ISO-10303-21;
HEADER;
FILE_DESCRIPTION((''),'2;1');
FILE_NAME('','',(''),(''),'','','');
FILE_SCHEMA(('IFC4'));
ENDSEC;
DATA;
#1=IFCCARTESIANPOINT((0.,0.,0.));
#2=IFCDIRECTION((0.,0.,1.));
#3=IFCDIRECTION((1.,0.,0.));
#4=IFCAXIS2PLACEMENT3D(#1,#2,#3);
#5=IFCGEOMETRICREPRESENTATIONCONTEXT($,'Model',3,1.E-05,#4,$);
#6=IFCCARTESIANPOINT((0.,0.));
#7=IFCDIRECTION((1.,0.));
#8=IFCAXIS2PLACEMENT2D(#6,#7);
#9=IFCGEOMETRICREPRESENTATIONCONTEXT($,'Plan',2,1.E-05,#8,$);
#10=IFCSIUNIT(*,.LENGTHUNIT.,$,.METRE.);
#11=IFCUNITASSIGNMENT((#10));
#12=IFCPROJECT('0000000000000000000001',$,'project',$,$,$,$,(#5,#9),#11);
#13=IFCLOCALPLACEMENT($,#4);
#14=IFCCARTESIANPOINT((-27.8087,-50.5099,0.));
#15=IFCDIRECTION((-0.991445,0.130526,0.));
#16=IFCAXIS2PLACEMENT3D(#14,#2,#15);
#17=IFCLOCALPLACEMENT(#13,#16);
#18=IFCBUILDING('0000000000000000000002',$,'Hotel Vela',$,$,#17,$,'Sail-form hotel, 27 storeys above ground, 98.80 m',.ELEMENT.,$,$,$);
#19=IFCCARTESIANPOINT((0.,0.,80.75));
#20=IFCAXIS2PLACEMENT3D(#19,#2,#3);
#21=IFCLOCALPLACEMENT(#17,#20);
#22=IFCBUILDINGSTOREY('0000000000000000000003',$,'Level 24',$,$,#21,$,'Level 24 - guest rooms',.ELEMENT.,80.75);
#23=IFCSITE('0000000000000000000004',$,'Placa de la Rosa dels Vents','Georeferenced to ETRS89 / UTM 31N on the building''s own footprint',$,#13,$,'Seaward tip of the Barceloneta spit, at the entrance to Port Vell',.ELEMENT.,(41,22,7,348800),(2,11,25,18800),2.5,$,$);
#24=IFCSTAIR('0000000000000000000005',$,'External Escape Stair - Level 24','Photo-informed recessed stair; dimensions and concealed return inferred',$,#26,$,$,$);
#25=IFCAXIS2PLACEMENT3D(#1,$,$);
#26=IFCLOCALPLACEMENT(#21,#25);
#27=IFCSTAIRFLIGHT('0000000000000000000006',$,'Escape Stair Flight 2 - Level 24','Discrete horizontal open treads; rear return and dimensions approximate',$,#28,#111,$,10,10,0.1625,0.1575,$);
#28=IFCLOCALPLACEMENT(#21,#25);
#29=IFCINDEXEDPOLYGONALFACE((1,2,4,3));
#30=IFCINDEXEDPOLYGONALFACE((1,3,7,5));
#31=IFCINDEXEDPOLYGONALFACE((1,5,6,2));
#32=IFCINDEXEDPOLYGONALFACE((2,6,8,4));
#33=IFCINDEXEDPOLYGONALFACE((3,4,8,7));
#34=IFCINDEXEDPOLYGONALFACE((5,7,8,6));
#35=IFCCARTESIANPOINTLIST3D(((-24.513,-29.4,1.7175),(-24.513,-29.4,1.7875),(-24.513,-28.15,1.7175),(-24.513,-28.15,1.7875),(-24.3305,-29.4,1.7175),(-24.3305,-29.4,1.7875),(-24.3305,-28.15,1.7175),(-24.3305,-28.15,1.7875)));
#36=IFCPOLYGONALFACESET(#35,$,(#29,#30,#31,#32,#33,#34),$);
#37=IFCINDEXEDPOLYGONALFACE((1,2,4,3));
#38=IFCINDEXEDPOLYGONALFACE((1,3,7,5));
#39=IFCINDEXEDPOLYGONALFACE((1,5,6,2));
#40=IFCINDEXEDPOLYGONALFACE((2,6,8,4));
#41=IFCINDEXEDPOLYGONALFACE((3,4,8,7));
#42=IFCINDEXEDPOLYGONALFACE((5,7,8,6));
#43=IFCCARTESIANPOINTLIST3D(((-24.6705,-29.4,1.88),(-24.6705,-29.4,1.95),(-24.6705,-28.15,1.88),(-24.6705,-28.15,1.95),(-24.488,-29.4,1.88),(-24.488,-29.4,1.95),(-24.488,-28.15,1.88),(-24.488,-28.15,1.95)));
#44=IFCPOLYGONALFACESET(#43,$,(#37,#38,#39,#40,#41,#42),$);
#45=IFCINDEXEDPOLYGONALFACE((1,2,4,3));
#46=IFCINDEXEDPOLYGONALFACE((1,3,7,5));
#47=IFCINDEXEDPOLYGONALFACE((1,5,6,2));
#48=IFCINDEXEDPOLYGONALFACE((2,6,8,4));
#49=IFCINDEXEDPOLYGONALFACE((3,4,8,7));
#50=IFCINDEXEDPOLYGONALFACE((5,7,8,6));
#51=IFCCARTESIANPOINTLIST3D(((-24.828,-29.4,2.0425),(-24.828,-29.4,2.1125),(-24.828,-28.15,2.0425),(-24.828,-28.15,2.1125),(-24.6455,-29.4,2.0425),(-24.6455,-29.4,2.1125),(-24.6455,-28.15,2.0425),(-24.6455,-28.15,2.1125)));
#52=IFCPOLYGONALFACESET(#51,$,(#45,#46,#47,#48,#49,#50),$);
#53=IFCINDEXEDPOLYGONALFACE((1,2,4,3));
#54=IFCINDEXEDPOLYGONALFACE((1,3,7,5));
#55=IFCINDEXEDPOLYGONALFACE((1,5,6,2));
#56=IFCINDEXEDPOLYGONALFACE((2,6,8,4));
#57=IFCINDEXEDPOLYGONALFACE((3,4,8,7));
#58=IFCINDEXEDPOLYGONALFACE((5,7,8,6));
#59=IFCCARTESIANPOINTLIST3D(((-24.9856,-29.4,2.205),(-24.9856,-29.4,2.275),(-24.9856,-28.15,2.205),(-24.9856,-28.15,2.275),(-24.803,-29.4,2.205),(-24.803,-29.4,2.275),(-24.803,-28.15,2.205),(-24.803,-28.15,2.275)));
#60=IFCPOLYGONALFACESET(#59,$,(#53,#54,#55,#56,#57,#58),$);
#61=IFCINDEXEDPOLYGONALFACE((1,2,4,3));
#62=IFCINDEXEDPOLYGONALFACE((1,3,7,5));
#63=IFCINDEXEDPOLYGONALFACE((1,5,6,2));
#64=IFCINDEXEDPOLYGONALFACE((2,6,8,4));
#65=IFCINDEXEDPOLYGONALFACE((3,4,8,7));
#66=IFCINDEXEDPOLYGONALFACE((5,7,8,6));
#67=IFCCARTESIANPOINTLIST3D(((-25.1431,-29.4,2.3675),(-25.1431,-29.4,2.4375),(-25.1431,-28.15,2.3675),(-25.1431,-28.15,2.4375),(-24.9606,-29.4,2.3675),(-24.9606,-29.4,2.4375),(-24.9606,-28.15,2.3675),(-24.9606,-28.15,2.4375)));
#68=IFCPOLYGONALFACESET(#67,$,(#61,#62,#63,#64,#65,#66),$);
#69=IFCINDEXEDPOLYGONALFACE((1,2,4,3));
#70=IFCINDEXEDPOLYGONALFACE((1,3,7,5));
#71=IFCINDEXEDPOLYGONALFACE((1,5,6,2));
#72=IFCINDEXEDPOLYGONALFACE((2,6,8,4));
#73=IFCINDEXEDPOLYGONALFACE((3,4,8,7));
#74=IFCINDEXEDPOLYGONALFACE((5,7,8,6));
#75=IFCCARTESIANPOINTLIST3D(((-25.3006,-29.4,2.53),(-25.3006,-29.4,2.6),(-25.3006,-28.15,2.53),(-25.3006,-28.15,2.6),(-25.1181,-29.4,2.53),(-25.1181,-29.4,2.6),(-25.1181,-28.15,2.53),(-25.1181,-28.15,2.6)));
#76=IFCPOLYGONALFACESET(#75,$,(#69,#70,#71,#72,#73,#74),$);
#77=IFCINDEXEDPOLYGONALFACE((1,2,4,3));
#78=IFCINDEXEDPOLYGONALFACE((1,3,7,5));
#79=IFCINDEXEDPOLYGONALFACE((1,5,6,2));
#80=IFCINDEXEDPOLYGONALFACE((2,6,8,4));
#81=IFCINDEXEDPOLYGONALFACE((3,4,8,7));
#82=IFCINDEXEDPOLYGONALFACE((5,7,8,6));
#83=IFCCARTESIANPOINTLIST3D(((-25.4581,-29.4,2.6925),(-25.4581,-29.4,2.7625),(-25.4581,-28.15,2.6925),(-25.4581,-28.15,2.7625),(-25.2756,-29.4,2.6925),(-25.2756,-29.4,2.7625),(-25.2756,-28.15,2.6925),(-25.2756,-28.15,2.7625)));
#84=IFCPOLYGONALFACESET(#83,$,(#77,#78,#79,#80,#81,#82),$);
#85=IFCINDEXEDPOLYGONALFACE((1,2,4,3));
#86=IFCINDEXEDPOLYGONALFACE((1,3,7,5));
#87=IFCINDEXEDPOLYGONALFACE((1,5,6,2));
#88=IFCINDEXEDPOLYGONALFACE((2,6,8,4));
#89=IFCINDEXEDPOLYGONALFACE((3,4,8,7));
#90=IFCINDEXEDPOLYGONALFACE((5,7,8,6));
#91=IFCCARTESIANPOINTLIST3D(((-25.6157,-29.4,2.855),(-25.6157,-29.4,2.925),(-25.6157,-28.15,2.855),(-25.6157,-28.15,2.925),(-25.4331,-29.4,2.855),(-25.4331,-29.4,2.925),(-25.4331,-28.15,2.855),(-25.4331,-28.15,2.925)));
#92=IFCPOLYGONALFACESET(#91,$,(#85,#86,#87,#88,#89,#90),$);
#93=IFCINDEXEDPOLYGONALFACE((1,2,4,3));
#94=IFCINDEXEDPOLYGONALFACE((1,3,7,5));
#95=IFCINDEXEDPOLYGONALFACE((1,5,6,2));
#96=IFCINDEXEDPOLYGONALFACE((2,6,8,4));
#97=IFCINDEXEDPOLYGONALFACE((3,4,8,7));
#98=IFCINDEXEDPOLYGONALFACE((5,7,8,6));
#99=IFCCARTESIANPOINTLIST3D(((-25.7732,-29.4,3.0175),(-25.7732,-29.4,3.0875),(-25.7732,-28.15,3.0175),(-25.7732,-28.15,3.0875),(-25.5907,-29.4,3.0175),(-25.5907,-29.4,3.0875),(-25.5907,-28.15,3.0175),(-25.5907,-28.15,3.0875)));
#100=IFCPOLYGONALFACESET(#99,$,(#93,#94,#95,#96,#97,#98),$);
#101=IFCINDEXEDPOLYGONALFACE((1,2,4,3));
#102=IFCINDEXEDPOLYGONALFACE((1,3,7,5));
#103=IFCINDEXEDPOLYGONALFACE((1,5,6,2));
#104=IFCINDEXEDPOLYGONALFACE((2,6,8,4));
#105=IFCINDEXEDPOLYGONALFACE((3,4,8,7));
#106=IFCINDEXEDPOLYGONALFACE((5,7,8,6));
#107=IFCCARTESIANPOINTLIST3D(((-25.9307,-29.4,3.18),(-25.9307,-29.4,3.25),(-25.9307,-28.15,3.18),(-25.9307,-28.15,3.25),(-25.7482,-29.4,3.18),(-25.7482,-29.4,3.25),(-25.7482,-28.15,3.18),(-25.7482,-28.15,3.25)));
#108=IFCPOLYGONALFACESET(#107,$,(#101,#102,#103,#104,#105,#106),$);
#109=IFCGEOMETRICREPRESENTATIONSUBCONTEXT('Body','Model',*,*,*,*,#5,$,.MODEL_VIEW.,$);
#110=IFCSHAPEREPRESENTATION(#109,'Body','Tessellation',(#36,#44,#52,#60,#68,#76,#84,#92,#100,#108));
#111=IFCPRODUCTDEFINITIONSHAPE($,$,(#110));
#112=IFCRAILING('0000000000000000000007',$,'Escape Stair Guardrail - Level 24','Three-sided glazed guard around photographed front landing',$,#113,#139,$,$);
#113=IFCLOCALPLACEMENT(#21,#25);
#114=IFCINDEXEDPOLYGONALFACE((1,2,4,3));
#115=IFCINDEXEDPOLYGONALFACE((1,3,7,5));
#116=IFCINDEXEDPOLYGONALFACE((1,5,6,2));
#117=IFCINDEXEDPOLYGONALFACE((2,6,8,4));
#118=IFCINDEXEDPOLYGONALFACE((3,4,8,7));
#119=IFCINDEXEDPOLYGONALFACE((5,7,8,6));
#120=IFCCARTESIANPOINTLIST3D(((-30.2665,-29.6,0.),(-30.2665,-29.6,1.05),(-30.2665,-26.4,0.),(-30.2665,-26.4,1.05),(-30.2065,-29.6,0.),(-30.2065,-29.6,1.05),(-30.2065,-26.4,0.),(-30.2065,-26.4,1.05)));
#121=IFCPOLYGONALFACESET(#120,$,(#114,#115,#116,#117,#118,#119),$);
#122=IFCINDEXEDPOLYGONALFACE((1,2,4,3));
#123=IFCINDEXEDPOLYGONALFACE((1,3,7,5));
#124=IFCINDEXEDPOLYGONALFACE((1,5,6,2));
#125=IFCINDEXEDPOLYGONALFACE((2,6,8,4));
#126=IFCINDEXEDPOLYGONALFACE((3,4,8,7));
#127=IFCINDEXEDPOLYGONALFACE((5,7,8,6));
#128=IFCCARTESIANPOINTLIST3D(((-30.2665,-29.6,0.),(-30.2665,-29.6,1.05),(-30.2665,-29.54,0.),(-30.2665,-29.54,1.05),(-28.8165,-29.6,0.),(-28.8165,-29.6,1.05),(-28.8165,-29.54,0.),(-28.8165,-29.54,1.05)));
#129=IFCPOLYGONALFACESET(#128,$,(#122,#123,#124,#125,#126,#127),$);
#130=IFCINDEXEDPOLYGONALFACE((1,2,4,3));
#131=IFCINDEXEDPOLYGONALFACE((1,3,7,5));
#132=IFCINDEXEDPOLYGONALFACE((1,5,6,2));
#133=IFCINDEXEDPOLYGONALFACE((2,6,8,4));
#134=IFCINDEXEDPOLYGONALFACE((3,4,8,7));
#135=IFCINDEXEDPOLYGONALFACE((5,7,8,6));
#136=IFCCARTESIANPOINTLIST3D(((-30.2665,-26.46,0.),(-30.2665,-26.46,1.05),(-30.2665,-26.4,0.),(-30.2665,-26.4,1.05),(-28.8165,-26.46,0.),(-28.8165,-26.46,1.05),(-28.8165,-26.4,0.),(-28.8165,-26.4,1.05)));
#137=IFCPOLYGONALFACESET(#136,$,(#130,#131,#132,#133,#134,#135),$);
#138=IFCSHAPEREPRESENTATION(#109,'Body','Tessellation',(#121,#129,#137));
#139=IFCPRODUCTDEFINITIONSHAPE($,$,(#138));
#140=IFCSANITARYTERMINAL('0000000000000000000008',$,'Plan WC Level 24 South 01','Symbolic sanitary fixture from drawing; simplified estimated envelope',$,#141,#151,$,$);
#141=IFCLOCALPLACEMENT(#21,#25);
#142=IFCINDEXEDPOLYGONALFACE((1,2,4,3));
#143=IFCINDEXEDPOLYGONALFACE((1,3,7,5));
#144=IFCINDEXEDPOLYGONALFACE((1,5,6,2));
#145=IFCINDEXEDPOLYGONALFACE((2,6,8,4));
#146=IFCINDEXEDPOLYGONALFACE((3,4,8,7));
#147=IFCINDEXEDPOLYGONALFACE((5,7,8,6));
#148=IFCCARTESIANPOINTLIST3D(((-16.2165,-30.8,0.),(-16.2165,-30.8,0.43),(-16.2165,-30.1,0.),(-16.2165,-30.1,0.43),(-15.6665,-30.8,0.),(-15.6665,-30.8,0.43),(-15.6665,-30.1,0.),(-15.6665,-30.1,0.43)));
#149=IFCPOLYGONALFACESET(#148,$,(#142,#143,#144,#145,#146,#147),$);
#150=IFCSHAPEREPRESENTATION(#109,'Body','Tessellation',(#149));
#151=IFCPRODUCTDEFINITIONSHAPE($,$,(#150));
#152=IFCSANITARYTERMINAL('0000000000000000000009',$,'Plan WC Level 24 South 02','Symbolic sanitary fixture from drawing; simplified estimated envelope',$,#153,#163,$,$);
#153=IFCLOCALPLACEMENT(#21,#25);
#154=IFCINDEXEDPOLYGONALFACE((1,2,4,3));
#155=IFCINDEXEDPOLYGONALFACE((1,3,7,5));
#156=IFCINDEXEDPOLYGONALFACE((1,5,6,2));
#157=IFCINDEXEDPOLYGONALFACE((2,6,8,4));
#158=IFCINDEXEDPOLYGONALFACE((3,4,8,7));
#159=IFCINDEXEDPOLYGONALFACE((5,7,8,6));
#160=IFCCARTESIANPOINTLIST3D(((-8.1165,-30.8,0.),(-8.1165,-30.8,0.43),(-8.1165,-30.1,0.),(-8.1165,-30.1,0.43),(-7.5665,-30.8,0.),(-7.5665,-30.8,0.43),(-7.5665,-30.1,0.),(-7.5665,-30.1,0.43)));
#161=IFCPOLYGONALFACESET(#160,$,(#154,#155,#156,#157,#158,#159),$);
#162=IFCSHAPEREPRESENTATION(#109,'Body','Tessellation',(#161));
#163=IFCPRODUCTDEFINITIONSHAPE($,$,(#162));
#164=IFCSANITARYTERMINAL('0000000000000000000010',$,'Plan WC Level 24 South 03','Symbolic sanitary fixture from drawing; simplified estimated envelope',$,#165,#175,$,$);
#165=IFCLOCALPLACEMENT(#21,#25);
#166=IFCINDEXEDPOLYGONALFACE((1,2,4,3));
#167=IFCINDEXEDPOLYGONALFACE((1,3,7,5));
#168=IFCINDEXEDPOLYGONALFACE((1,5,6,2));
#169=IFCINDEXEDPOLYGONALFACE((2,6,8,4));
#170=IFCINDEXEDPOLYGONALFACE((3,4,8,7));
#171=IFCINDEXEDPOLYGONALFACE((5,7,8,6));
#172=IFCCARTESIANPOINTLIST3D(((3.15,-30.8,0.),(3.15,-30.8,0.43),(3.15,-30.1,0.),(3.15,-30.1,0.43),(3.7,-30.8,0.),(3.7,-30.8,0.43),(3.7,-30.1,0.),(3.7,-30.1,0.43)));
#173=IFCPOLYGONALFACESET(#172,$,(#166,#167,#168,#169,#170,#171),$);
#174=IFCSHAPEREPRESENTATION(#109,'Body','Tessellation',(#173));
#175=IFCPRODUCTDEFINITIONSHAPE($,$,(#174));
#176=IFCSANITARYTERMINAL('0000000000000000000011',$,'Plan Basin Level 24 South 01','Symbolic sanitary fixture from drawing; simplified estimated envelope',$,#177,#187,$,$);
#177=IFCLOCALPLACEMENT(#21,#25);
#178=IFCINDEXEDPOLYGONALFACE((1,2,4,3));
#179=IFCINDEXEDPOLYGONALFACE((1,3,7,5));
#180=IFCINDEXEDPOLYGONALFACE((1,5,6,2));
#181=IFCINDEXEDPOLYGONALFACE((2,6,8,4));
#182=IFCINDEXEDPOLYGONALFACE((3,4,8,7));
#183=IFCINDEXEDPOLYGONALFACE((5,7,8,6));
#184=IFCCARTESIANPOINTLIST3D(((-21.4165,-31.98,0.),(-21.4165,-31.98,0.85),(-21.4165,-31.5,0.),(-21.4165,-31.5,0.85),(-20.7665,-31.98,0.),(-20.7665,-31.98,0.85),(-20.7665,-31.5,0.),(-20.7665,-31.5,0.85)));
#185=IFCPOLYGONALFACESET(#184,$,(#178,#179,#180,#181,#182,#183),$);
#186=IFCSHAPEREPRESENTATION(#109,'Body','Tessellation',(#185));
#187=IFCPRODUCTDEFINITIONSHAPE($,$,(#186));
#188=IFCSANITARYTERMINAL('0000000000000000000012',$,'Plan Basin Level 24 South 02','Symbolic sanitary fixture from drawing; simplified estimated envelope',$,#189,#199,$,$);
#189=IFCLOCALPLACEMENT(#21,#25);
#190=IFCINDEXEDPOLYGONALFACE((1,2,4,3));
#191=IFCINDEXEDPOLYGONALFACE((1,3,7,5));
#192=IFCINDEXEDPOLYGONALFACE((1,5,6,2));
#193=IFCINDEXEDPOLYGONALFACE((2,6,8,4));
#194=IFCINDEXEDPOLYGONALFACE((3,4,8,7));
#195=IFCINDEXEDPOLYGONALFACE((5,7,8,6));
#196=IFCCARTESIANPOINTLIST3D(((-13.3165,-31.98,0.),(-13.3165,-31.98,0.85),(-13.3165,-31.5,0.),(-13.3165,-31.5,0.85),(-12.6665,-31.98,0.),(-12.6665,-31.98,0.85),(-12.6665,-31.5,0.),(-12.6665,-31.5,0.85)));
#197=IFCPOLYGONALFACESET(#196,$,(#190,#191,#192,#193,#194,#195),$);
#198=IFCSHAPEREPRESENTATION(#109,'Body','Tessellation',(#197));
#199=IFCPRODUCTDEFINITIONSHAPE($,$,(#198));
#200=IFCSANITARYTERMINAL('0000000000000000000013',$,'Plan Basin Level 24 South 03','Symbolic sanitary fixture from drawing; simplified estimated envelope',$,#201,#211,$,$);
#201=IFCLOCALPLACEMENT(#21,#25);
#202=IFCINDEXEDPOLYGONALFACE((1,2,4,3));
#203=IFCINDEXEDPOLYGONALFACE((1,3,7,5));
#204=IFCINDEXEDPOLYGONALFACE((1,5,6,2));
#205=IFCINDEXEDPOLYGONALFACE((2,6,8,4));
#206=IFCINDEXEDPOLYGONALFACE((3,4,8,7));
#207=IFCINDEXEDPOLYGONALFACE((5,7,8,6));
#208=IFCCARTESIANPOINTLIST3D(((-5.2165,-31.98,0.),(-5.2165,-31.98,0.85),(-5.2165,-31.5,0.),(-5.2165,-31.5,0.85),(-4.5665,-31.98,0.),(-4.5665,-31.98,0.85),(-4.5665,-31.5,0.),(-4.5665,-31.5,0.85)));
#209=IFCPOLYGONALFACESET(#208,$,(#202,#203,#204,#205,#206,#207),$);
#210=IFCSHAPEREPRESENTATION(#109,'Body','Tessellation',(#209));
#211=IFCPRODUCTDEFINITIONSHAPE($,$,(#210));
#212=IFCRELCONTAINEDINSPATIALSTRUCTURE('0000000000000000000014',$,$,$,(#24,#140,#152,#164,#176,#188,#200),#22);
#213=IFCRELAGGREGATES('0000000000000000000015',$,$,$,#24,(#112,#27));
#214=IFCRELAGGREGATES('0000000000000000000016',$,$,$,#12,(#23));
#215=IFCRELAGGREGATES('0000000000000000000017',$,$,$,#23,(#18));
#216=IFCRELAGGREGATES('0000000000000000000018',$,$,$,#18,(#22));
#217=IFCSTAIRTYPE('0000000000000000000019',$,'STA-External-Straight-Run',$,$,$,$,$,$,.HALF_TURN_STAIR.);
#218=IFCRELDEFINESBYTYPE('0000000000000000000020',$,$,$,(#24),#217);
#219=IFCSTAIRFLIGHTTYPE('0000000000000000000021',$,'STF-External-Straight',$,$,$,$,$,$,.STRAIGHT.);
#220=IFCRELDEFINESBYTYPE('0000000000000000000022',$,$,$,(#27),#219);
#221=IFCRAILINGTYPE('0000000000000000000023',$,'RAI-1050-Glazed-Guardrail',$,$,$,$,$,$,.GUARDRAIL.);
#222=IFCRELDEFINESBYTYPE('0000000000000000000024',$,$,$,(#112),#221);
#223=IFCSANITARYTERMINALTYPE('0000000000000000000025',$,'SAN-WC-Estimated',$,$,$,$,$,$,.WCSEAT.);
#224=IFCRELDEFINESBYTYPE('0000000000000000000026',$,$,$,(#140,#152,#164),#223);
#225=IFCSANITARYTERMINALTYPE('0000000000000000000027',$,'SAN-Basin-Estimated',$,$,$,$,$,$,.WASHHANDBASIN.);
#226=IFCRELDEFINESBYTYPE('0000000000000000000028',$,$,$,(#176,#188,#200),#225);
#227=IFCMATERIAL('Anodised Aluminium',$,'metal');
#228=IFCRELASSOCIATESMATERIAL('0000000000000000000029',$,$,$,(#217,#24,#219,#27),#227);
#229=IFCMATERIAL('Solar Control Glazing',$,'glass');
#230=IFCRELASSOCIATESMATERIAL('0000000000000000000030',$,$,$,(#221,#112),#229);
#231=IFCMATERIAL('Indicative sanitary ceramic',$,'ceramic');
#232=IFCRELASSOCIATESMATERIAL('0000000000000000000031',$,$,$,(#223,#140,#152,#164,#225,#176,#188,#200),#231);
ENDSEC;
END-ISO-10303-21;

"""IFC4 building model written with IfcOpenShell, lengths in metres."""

from ifc_helpers import new_model, si_unit, frame, origin_with_axes, origin_2d_with_axis, place, context, subcontext, project, spatial, line, indexed_curve, outline, extrude, material, type_object, element, aggregate, save


model = new_model("IFC4")

# Units and contexts
model_context = context("Model", 3, precision=1e-05, world=origin_with_axes())
plan_context = context("Plan", 2, precision=1e-05, world=origin_2d_with_axis())
body_context = subcontext(model_context, "Body", "Model", "MODEL_VIEW")
ifc_project = project(units=[si_unit("LENGTHUNIT", "METRE")], contexts=[model_context, plan_context])

# Site, building, storey
site_placement = place(None, origin_with_axes())
site = spatial("IfcSite", under=ifc_project, at=site_placement, Name="Placa de la Rosa dels Vents", Description="Georeferenced to ETRS89 / UTM 31N on the building's own footprint", LongName="Seaward tip of the Barceloneta spit, at the entrance to Port Vell", CompositionType="ELEMENT", RefLatitude=(41, 22, 7, 348800), RefLongitude=(2, 11, 25, 18800), RefElevation=2.5)
building_placement = place(site_placement, frame((-27.8087, -50.5099, 0.0), z_axis=(0.0, 0.0, 1.0), x_axis=(-0.991445, 0.130526, 0.0)))
building = spatial("IfcBuilding", under=site, at=building_placement, Name="Hotel Vela", LongName="Sail-form hotel, 27 storeys above ground, 98.80 m", CompositionType="ELEMENT")
storey_placement = place(building_placement, frame((0.0, 0.0, 80.75), z_axis=(0.0, 0.0, 1.0), x_axis=(1.0, 0.0, 0.0)))
storey = spatial("IfcBuildingStorey", under=building, at=storey_placement, Name="Level 24", LongName="Level 24 - guest rooms", CompositionType="ELEMENT", Elevation=80.75)

# Stair
ifc_material_1 = material(Name="Anodised Aluminium", Category="metal")
stair_type = type_object("IfcStairType", Name="STA-External-Straight-Run", PredefinedType="HALF_TURN_STAIR", material=ifc_material_1)
stair_placement = place(storey_placement, frame((0.0, 0.0, -80.75), z_axis=(0.0, 0.0, 1.0), x_axis=(1.0, 0.0, 0.0)))
stair = element("IfcStair", 1, at=stair_placement, inside=storey, type_object=stair_type, material=ifc_material_1, Name="External Escape Stair - Level 24", Description="Photo-informed recessed stair; dimensions and concealed return inferred")

# Stair flight
stair_flight_type = type_object("IfcStairFlightType", Name="STF-External-Straight", PredefinedType="STRAIGHT", material=ifc_material_1)
stair_flight_1_placement = place(stair_placement, origin_with_axes())
stair_flight_1 = element("IfcStairFlight", 2, at=stair_flight_1_placement, type_object=stair_flight_type, material=ifc_material_1, Name="Escape Stair Flight 2 - Level 24", Description="Discrete horizontal open treads; rear return and dimensions approximate", NumberOfRisers=10, NumberOfTreads=10, RiserHeight=0.1625, TreadLength=0.1575, context=body_context, shape_type="SweptSolid", body=[
    extrude(outline(indexed_curve([(0.0, 0.0), (0.1825, 0.0), (0.1825, 1.25), (0.0, 1.25)], segments=[line(1, 2, 3, 4, 1)])), frame((-24.513, -29.4, 82.4675), z_axis=(0.0, 0.0, 1.0), x_axis=(1.0, 0.0, 0.0)), (0.0, 0.0, 1.0), 0.07),
    extrude(outline(indexed_curve([(0.0, 0.0), (0.1825, 0.0), (0.1825, 1.25), (0.0, 1.25)], segments=[line(1, 2, 3, 4, 1)])), frame((-24.6705, -29.4, 82.63), z_axis=(0.0, 0.0, 1.0), x_axis=(1.0, 0.0, 0.0)), (0.0, 0.0, 1.0), 0.07),
    extrude(outline(indexed_curve([(0.0, 0.0), (0.1825, 0.0), (0.1825, 1.25), (0.0, 1.25)], segments=[line(1, 2, 3, 4, 1)])), frame((-24.828, -29.4, 82.7925), z_axis=(0.0, 0.0, 1.0), x_axis=(1.0, 0.0, 0.0)), (0.0, 0.0, 1.0), 0.07),
    extrude(outline(indexed_curve([(0.0, 0.0), (0.1825, 0.0), (0.1825, 1.25), (0.0, 1.25)], segments=[line(1, 2, 3, 4, 1)])), frame((-24.9856, -29.4, 82.955), z_axis=(0.0, 0.0, 1.0), x_axis=(1.0, 0.0, 0.0)), (0.0, 0.0, 1.0), 0.07),
    extrude(outline(indexed_curve([(0.0, 0.0), (0.1825, 0.0), (0.1825, 1.25), (0.0, 1.25)], segments=[line(1, 2, 3, 4, 1)])), frame((-25.1431, -29.4, 83.1175), z_axis=(0.0, 0.0, 1.0), x_axis=(1.0, 0.0, 0.0)), (0.0, 0.0, 1.0), 0.07),
    extrude(outline(indexed_curve([(0.0, 0.0), (0.1825, 0.0), (0.1825, 1.25), (0.0, 1.25)], segments=[line(1, 2, 3, 4, 1)])), frame((-25.3006, -29.4, 83.28), z_axis=(0.0, 0.0, 1.0), x_axis=(1.0, 0.0, 0.0)), (0.0, 0.0, 1.0), 0.07),
    extrude(outline(indexed_curve([(0.0, 0.0), (0.1825, 0.0), (0.1825, 1.25), (0.0, 1.25)], segments=[line(1, 2, 3, 4, 1)])), frame((-25.4581, -29.4, 83.4425), z_axis=(0.0, 0.0, 1.0), x_axis=(1.0, 0.0, 0.0)), (0.0, 0.0, 1.0), 0.07),
    extrude(outline(indexed_curve([(0.0, 0.0), (0.1825, 0.0), (0.1825, 1.25), (0.0, 1.25)], segments=[line(1, 2, 3, 4, 1)])), frame((-25.6157, -29.4, 83.605), z_axis=(0.0, 0.0, 1.0), x_axis=(1.0, 0.0, 0.0)), (0.0, 0.0, 1.0), 0.07),
    extrude(outline(indexed_curve([(0.0, 0.0), (0.1825, 0.0), (0.1825, 1.25), (0.0, 1.25)], segments=[line(1, 2, 3, 4, 1)])), frame((-25.7732, -29.4, 83.7675), z_axis=(0.0, 0.0, 1.0), x_axis=(1.0, 0.0, 0.0)), (0.0, 0.0, 1.0), 0.07),
    extrude(outline(indexed_curve([(0.0, 0.0), (0.1825, 0.0), (0.1825, 1.25), (0.0, 1.25)], segments=[line(1, 2, 3, 4, 1)])), frame((-25.9307, -29.4, 83.93), z_axis=(0.0, 0.0, 1.0), x_axis=(1.0, 0.0, 0.0)), (0.0, 0.0, 1.0), 0.07),
])

# Railing
ifc_material_2 = material(Name="Solar Control Glazing", Category="glass")
railing_type = type_object("IfcRailingType", Name="RAI-1050-Glazed-Guardrail", PredefinedType="GUARDRAIL", material=ifc_material_2)
railing_placement = place(stair_placement, origin_with_axes())
railing = element("IfcRailing", 3, at=railing_placement, type_object=railing_type, material=ifc_material_2, Name="Escape Stair Guardrail - Level 24", Description="Three-sided glazed guard around photographed front landing", context=body_context, shape_type="SweptSolid", body=[
    extrude(outline(indexed_curve([(0.0, 0.0), (0.06, 0.0), (0.06, 3.2), (0.0, 3.2)], segments=[line(1, 2, 3, 4, 1)])), frame((-30.2665, -29.6, 80.75), z_axis=(0.0, 0.0, 1.0), x_axis=(1.0, 0.0, 0.0)), (0.0, 0.0, 1.0), 1.05),
    extrude(outline(indexed_curve([(0.0, 0.0), (1.45, 0.0), (1.45, 0.06), (0.0, 0.06)], segments=[line(1, 2, 3, 4, 1)])), frame((-30.2665, -29.6, 80.75), z_axis=(0.0, 0.0, 1.0), x_axis=(1.0, 0.0, 0.0)), (0.0, 0.0, 1.0), 1.05),
    extrude(outline(indexed_curve([(0.0, 0.0), (1.45, 0.0), (1.45, 0.06), (0.0, 0.06)], segments=[line(1, 2, 3, 4, 1)])), frame((-30.2665, -26.46, 80.75), z_axis=(0.0, 0.0, 1.0), x_axis=(1.0, 0.0, 0.0)), (0.0, 0.0, 1.0), 1.05),
])
aggregate(stair, [railing, stair_flight_1])

# Sanitary terminals
ifc_material_3 = material(Name="Indicative sanitary ceramic", Category="ceramic")
sanitary_terminal_type_1 = type_object("IfcSanitaryTerminalType", Name="SAN-WC-Estimated", PredefinedType="WCSEAT", material=ifc_material_3)
for number, where, z_axis, x_axis, name in (
    (4, (-16.2165, -30.8, 0.0), (0.0, 0.0, 1.0), (1.0, 0.0, 0.0), "Plan WC Level 24 South 01"),
    (5, (-8.1165, -30.8, 0.0), (0.0, 0.0, 1.0), (1.0, 0.0, 0.0), "Plan WC Level 24 South 02"),
    (6, (3.15, -30.8, 0.0), (0.0, 0.0, 1.0), (1.0, 0.0, 0.0), "Plan WC Level 24 South 03"),
):
    element("IfcSanitaryTerminal", number, at=place(storey_placement, frame(where, z_axis=z_axis, x_axis=x_axis)), inside=storey, type_object=sanitary_terminal_type_1, material=ifc_material_3, Name=name, Description="Symbolic sanitary fixture from drawing; simplified estimated envelope", context=body_context, shape_type="SweptSolid", body=[
        extrude(outline(indexed_curve([(0.0, 0.0), (0.55, 0.0), (0.55, 0.7), (0.0, 0.7)], segments=[line(1, 2, 3, 4, 1)])), origin_with_axes(), (0.0, 0.0, 1.0), 0.43),
    ])
sanitary_terminal_type_2 = type_object("IfcSanitaryTerminalType", Name="SAN-Basin-Estimated", PredefinedType="WASHHANDBASIN", material=ifc_material_3)
for number, where, z_axis, x_axis, name in (
    (7, (-21.4165, -31.98, 0.0), (0.0, 0.0, 1.0), (1.0, 0.0, 0.0), "Plan Basin Level 24 South 01"),
    (8, (-13.3165, -31.98, 0.0), (0.0, 0.0, 1.0), (1.0, 0.0, 0.0), "Plan Basin Level 24 South 02"),
    (9, (-5.2165, -31.98, 0.0), (0.0, 0.0, 1.0), (1.0, 0.0, 0.0), "Plan Basin Level 24 South 03"),
):
    element("IfcSanitaryTerminal", number, at=place(storey_placement, frame(where, z_axis=z_axis, x_axis=x_axis)), inside=storey, type_object=sanitary_terminal_type_2, material=ifc_material_3, Name=name, Description="Symbolic sanitary fixture from drawing; simplified estimated envelope", context=body_context, shape_type="SweptSolid", body=[
        extrude(outline(indexed_curve([(0.0, 0.0), (0.65, 0.0), (0.65, 0.48), (0.0, 0.48)], segments=[line(1, 2, 3, 4, 1)])), origin_with_axes(), (0.0, 0.0, 1.0), 0.85),
    ])

save(model, "model.ifc")
